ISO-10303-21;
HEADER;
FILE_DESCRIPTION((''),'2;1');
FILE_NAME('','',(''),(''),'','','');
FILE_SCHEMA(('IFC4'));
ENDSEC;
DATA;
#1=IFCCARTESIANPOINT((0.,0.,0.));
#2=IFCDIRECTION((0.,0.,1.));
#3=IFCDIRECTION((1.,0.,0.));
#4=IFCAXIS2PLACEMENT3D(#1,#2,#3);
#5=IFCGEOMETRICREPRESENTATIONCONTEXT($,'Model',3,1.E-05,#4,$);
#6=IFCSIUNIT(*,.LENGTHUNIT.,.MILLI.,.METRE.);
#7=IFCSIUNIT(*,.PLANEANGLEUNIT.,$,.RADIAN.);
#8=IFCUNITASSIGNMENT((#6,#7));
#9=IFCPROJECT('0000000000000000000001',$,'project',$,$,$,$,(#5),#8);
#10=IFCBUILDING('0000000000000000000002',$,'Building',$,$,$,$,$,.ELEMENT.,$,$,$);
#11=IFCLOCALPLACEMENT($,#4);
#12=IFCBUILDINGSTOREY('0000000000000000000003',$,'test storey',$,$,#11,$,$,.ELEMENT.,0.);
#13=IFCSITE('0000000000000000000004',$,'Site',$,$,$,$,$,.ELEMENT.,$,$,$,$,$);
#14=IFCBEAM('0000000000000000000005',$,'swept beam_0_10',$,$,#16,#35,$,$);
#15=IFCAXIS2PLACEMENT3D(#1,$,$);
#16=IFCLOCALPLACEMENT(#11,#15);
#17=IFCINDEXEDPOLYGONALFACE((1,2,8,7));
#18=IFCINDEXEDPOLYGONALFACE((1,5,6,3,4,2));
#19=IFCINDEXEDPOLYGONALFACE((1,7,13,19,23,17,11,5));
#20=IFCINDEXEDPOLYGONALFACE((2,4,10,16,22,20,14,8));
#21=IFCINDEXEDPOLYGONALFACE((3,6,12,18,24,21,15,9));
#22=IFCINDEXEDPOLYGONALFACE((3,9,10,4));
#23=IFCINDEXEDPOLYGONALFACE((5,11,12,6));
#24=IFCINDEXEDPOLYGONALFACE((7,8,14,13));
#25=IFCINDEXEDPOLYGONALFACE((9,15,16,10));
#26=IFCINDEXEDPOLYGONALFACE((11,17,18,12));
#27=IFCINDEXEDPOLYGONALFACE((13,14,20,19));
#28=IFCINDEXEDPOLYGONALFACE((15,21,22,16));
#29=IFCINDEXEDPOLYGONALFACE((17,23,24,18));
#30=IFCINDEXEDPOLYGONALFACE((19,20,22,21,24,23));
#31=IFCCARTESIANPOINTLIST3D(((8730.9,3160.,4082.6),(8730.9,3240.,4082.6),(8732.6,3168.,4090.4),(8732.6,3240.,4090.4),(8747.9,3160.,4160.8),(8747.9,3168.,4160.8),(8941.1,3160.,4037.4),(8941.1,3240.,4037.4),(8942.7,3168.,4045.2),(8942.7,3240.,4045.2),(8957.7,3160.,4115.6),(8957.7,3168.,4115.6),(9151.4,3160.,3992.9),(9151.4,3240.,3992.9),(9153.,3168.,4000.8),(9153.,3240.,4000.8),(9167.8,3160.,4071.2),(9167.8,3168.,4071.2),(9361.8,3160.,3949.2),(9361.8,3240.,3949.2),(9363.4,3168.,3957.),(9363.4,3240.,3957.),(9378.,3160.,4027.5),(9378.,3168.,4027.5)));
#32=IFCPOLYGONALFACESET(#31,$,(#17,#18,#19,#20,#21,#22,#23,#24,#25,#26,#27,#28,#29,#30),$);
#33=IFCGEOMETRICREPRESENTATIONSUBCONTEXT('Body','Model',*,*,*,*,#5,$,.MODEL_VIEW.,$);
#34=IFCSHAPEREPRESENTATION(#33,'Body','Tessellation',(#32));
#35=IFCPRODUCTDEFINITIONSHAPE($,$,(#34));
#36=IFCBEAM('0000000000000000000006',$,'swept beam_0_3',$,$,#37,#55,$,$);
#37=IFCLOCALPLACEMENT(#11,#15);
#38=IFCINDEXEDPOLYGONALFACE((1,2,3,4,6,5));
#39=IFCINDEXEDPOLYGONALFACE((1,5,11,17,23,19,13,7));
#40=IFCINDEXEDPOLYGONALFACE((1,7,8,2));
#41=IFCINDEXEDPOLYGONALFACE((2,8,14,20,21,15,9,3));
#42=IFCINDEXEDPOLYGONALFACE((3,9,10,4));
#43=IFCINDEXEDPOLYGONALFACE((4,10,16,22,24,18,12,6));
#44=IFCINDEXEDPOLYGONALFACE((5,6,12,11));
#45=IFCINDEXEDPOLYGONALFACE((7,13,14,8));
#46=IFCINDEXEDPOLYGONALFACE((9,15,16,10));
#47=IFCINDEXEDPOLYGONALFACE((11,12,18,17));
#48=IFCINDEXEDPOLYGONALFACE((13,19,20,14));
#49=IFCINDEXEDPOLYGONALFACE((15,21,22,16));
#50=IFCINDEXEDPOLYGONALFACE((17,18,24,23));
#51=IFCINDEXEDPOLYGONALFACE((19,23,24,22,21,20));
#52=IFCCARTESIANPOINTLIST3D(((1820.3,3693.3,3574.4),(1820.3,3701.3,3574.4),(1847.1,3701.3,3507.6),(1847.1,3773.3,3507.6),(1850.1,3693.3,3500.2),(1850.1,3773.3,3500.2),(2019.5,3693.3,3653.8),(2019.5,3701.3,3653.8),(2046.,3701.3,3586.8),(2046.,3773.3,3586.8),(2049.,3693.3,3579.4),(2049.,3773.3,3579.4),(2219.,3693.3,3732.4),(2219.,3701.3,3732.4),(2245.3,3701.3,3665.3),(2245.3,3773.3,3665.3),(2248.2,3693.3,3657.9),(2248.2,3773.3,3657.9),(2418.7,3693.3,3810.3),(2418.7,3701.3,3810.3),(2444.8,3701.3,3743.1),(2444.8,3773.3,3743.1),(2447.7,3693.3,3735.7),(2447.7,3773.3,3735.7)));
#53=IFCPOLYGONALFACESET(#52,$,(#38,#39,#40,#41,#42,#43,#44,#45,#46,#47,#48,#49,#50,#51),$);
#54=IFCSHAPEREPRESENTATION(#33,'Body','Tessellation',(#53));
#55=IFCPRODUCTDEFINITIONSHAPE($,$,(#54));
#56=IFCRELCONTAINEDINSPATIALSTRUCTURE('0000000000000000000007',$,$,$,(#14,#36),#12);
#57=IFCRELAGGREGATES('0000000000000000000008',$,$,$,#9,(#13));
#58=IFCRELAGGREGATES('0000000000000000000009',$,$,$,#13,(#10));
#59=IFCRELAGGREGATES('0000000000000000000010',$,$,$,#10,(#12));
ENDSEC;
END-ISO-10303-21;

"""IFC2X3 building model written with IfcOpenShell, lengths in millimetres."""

from ifc_helpers import new_model, entity, si_unit, origin_with_axes, place, context, subcontext, project, spatial, element, save


model = new_model("IFC2X3")

# Units and contexts
model_context = context("Model", 3, precision=1e-05, world=origin_with_axes())
body_context = subcontext(model_context, "Body", "Model", "MODEL_VIEW")
ifc_project = project(units=[si_unit("LENGTHUNIT", "METRE", prefix="MILLI"), si_unit("PLANEANGLEUNIT", "RADIAN")], contexts=[model_context])

# Site, building, storey
site = spatial("IfcSite", under=ifc_project, Name="Site", CompositionType="ELEMENT")
building = spatial("IfcBuilding", under=site, Name="Building", CompositionType="ELEMENT")
storey_placement = place(None, origin_with_axes())
storey = spatial("IfcBuildingStorey", under=building, at=storey_placement, Name="test storey", CompositionType="ELEMENT", Elevation=0.0)

# Beams
beam_1_placement = place(storey_placement, origin_with_axes())
element("IfcBeam", 1, at=beam_1_placement, inside=storey, Name="swept beam_0_10", context=body_context, shape_type="SweptSolid", body=[
    entity("IfcRevolvedAreaSolid", entity("IfcArbitraryClosedProfileDef", "AREA", None, entity("IfcPolyline", [entity("IfcCartesianPoint", [-80.0, 40.0]), entity("IfcCartesianPoint", [-80.0, 32.0]), entity("IfcCartesianPoint", [-8.0, 32.0]), entity("IfcCartesianPoint", [-8.0, -40.0]), entity("IfcCartesianPoint", [0.0, -40.0]), entity("IfcCartesianPoint", [0.0, 40.0]), entity("IfcCartesianPoint", [-80.0, 40.0])])), entity("IfcAxis2Placement3D", entity("IfcCartesianPoint", [8730.9, 3200.0, 4082.6]), entity("IfcDirection", [-0.9773, 0.0, 0.2119]), entity("IfcDirection", [-0.2119, 0.0, -0.9773])), entity("IfcAxis1Placement", entity("IfcCartesianPoint", [-62720.7, 0.0, 0.0]), entity("IfcDirection", [0.0, 1.0, 0.0])), 0.010281),
])
beam_2_placement = place(storey_placement, origin_with_axes())
element("IfcBeam", 2, at=beam_2_placement, inside=storey, Name="swept beam_0_3", context=body_context, shape_type="SweptSolid", body=[
    entity("IfcRevolvedAreaSolid", entity("IfcArbitraryClosedProfileDef", "AREA", None, entity("IfcPolyline", [entity("IfcCartesianPoint", [80.0, -40.0]), entity("IfcCartesianPoint", [80.0, -32.0]), entity("IfcCartesianPoint", [8.0, -32.0]), entity("IfcCartesianPoint", [8.0, 40.0]), entity("IfcCartesianPoint", [0.0, 40.0]), entity("IfcCartesianPoint", [0.0, -40.0]), entity("IfcCartesianPoint", [80.0, -40.0])])), entity("IfcAxis2Placement3D", entity("IfcCartesianPoint", [1850.1, 3733.3, 3500.2]), entity("IfcDirection", [-0.9284, 0.0, -0.3717]), entity("IfcDirection", [-0.3717, 0.0, 0.9284])), entity("IfcAxis1Placement", entity("IfcCartesianPoint", [-59249.8, 0.0, 0.0]), entity("IfcDirection", [0.0, 1.0, 0.0])), 0.010841),
])

save(model, "model.ifc")
